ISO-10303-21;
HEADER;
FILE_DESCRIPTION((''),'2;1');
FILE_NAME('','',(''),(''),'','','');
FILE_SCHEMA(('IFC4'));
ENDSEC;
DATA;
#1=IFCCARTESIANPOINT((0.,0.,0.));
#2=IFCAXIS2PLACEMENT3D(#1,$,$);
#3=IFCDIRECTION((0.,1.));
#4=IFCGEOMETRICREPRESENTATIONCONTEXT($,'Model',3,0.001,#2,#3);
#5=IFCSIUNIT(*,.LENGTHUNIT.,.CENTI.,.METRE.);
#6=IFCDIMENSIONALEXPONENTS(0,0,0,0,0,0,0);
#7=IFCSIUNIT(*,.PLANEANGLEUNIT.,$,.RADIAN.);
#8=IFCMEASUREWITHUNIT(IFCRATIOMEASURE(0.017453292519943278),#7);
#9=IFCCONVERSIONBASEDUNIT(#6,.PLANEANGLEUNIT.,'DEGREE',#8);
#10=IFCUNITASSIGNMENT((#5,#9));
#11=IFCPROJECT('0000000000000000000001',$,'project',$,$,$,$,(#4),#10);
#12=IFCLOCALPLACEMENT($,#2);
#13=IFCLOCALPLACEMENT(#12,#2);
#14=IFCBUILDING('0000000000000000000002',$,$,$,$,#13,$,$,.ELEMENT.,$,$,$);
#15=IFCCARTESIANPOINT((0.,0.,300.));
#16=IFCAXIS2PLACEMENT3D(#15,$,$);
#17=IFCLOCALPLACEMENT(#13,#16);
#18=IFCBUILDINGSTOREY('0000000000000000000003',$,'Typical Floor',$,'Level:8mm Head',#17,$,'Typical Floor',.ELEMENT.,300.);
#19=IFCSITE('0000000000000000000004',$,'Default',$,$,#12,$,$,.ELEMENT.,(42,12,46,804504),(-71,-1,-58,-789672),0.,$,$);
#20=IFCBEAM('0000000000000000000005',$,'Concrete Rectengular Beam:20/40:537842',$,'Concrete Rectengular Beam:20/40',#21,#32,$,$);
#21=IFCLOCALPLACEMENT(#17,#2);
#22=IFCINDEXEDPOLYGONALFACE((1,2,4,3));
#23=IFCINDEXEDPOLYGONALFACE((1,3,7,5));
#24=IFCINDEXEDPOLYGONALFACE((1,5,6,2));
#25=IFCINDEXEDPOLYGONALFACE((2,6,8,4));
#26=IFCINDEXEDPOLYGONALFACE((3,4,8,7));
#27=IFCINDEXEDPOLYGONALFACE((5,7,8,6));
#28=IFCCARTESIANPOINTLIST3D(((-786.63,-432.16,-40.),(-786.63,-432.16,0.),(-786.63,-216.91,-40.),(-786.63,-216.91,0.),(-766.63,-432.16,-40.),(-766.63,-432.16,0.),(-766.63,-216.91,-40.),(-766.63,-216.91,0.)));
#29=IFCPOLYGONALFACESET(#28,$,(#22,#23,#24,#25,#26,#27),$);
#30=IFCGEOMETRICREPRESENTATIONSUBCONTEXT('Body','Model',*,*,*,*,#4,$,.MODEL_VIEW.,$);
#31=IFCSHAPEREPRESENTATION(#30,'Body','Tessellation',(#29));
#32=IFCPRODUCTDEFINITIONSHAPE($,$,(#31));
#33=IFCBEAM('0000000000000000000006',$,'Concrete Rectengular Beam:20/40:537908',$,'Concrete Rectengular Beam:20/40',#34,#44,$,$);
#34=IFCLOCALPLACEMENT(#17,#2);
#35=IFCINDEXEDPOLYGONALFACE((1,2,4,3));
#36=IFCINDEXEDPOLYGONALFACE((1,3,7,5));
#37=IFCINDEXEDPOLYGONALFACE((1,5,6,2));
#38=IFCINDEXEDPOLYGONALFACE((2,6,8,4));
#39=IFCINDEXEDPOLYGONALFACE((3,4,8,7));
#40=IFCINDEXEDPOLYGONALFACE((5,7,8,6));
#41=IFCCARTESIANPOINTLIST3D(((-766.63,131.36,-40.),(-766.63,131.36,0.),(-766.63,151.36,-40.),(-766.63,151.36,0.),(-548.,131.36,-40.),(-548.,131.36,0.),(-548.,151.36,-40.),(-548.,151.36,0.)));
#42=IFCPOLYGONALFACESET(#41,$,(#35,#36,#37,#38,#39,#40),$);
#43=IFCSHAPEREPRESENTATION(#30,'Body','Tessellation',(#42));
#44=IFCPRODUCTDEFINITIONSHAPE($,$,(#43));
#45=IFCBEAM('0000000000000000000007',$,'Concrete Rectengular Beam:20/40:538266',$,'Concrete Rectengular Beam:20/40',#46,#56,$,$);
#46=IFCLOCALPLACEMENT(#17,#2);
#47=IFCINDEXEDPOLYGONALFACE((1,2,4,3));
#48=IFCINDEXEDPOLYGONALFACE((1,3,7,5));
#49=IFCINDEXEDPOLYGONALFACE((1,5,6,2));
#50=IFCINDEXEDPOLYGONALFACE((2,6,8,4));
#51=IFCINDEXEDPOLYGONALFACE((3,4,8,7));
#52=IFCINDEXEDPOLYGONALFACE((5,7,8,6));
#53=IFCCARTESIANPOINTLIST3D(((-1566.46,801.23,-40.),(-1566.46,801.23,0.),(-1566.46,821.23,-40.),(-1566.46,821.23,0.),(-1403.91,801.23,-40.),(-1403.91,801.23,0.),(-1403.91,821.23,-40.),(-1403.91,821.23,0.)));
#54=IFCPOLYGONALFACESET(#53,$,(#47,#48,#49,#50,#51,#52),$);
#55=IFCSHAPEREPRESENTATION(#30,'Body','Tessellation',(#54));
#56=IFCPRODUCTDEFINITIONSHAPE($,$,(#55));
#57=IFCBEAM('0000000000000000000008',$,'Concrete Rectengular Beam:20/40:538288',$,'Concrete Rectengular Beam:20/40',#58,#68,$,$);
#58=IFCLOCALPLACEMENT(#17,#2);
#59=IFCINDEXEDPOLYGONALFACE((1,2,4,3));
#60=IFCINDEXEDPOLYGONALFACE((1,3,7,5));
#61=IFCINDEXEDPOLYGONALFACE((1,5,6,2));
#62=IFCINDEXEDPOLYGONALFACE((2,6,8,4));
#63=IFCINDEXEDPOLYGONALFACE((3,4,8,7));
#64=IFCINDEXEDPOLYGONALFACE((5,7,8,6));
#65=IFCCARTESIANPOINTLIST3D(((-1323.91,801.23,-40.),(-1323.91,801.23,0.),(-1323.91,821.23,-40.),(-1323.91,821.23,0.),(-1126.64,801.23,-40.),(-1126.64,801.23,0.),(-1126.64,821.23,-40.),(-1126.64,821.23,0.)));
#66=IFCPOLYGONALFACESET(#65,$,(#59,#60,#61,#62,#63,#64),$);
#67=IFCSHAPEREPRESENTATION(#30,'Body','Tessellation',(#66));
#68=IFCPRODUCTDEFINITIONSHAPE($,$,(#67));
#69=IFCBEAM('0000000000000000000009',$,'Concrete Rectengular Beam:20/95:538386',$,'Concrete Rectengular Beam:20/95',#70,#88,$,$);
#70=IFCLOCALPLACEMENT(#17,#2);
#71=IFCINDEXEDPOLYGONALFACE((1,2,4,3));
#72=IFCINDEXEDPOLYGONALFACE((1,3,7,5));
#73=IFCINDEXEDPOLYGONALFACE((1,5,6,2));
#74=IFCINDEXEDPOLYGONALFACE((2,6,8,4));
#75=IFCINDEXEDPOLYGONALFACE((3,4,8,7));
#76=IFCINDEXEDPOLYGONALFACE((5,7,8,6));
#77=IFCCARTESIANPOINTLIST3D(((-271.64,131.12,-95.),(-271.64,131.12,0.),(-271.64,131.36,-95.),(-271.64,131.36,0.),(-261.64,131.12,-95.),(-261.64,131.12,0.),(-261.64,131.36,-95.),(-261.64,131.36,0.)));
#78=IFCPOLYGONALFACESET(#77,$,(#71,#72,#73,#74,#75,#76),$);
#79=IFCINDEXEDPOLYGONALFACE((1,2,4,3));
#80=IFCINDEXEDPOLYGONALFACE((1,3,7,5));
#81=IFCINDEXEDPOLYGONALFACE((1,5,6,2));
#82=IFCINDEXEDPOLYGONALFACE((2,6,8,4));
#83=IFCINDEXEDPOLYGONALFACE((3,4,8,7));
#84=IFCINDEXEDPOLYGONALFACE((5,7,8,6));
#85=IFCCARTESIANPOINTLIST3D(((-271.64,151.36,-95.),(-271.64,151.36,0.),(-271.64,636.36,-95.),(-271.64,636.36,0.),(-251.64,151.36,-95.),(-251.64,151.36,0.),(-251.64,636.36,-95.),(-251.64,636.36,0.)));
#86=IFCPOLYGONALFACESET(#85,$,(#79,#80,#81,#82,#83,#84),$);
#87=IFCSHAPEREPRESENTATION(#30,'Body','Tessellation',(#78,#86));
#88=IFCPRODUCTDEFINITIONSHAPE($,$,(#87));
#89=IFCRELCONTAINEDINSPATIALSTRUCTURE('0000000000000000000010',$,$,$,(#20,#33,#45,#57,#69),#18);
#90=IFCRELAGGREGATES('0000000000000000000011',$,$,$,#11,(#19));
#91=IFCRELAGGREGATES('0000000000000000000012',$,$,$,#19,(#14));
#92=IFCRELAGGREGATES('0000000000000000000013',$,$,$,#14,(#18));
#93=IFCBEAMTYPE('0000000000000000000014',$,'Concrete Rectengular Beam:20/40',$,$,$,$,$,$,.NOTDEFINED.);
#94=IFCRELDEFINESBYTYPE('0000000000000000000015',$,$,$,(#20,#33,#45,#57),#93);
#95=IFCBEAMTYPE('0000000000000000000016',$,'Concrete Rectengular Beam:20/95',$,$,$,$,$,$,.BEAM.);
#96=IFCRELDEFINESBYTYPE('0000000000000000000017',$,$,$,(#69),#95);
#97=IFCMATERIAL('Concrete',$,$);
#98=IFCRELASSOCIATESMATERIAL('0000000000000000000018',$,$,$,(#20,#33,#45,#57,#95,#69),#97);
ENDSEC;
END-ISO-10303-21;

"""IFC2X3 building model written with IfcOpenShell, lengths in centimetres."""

from ifc_helpers import new_model, entity, si_unit, converted_unit, direction, frame, frame_2d, origin, place, context, subcontext, project, spatial, rectangle, extrude, source, transform, mapped, material, type_object, type_shapes, element, save


model = new_model("IFC2X3")

# Units and contexts
model_context = context("Model", 3, precision=0.001, world=origin(), true_north=direction((0.0, 1.0)))
body_context = subcontext(model_context, "Body", "Model", "MODEL_VIEW")
ifc_project = project(units=[si_unit("LENGTHUNIT", "METRE", prefix="CENTI"), converted_unit("PLANEANGLEUNIT", "DEGREE", entity("IfcRatioMeasure", 0.017453292519943278), si_unit("PLANEANGLEUNIT", "RADIAN"), dimensions=[0, 0, 0, 0, 0, 0, 0])], contexts=[model_context])

# Site, building, storey
site_placement = place(None, origin())
site = spatial("IfcSite", under=ifc_project, at=site_placement, Name="Default", CompositionType="ELEMENT", RefLatitude=(42, 12, 46, 804504), RefLongitude=(-71, -1, -58, -789672), RefElevation=0.0)
building_placement = place(site_placement, origin())
building = spatial("IfcBuilding", under=site, at=building_placement, CompositionType="ELEMENT")
storey_placement = place(building_placement, frame((0.0, 0.0, 300.0)))
storey = spatial("IfcBuildingStorey", under=building, at=storey_placement, Name="Typical Floor", ObjectType="Level:8mm Head", LongName="Typical Floor", CompositionType="ELEMENT", Elevation=300.0)

# Beams
ifc_material = material(Name="Concrete")
beam_type_1 = type_object("IfcBeamType", Name="Concrete Rectengular Beam:20/40", PredefinedType="NOTDEFINED")
beam_1_placement = place(storey_placement, frame((-776.63, -472.16, 0.0), z_axis=(0.0, 0.0, 1.0), x_axis=(0.0, 1.0, 0.0)))
element("IfcBeam", 1, at=beam_1_placement, inside=storey, type_object=beam_type_1, material=ifc_material, Name="Concrete Rectengular Beam:20/40:537842", ObjectType="Concrete Rectengular Beam:20/40", context=body_context, shape_type="SweptSolid", body=[
    extrude(rectangle(XDim=40.0, YDim=20.0, at=frame_2d((0.0, 0.0), x_axis=(1.0, 0.0))), frame((40.0, 0.0, -20.0), z_axis=(1.0, 0.0, 0.0), x_axis=(0.0, 0.0, -1.0)), (0.0, 0.0, 1.0), 215.25),
])
beam_2_placement = place(storey_placement, frame((-776.63, 141.36, 0.0)))
element("IfcBeam", 2, at=beam_2_placement, inside=storey, type_object=beam_type_1, material=ifc_material, Name="Concrete Rectengular Beam:20/40:537908", ObjectType="Concrete Rectengular Beam:20/40", context=body_context, shape_type="SweptSolid", body=[
    extrude(rectangle(XDim=40.0, YDim=20.0, at=frame_2d((0.0, 0.0), x_axis=(1.0, 0.0))), frame((10.0, 0.0, -20.0), z_axis=(1.0, 0.0, 0.0), x_axis=(0.0, 0.0, -1.0)), (0.0, 0.0, 1.0), 218.63),
])
beam_3_placement = place(storey_placement, frame((-1606.46, 811.23, 0.0)))
element("IfcBeam", 3, at=beam_3_placement, inside=storey, type_object=beam_type_1, material=ifc_material, Name="Concrete Rectengular Beam:20/40:538266", ObjectType="Concrete Rectengular Beam:20/40", context=body_context, shape_type="SweptSolid", body=[
    extrude(rectangle(XDim=40.0, YDim=20.0, at=frame_2d((0.0, 0.0), x_axis=(1.0, 0.0))), frame((40.0, 0.0, -20.0), z_axis=(1.0, 0.0, 0.0), x_axis=(0.0, 0.0, -1.0)), (0.0, 0.0, 1.0), 162.55),
])
beam_4_placement = place(storey_placement, frame((-1363.91, 811.23, 0.0)))
element("IfcBeam", 4, at=beam_4_placement, inside=storey, type_object=beam_type_1, material=ifc_material, Name="Concrete Rectengular Beam:20/40:538288", ObjectType="Concrete Rectengular Beam:20/40", context=body_context, shape_type="SweptSolid", body=[
    extrude(rectangle(XDim=40.0, YDim=20.0, at=frame_2d((0.0, 0.0), x_axis=(1.0, 0.0))), frame((40.0, 0.0, -20.0), z_axis=(1.0, 0.0, 0.0), x_axis=(0.0, 0.0, -1.0)), (0.0, 0.0, 1.0), 197.26),
])
beam_type_2 = type_object("IfcBeamType", Name="Concrete Rectengular Beam:20/95", PredefinedType="BEAM", material=ifc_material)
shared_shape_1 = source(origin(), body_context, "Body", "SweptSolid", [
    extrude(rectangle(XDim=95.0, YDim=10.0, at=frame_2d((0.0, 0.0), x_axis=(0.0, 1.0))), frame((-266.64, 131.36, 252.5), z_axis=(0.0, -1.0, 0.0), x_axis=(-1.0, 0.0, 0.0)), (0.0, 0.0, 1.0), 0.24),
    extrude(rectangle(XDim=95.0, YDim=20.0, at=frame_2d((0.0, 0.0), x_axis=(0.0, 1.0))), frame((-261.64, 636.36, 252.5), z_axis=(0.0, -1.0, 0.0), x_axis=(-1.0, 0.0, 0.0)), (0.0, 0.0, 1.0), 485.0),
])
type_shapes(beam_type_2, [shared_shape_1])
beam_5_placement = place(storey_placement, frame((0.0, 0.0, -300.0)))
element("IfcBeam", 5, at=beam_5_placement, inside=storey, type_object=beam_type_2, material=ifc_material, Name="Concrete Rectengular Beam:20/95:538386", ObjectType="Concrete Rectengular Beam:20/95", context=body_context, shape_type="MappedRepresentation", body=[
    mapped(shared_shape_1, transform((0.0, 0.0, 0.0), scale=1.0)),
])

save(model, "model.ifc")
